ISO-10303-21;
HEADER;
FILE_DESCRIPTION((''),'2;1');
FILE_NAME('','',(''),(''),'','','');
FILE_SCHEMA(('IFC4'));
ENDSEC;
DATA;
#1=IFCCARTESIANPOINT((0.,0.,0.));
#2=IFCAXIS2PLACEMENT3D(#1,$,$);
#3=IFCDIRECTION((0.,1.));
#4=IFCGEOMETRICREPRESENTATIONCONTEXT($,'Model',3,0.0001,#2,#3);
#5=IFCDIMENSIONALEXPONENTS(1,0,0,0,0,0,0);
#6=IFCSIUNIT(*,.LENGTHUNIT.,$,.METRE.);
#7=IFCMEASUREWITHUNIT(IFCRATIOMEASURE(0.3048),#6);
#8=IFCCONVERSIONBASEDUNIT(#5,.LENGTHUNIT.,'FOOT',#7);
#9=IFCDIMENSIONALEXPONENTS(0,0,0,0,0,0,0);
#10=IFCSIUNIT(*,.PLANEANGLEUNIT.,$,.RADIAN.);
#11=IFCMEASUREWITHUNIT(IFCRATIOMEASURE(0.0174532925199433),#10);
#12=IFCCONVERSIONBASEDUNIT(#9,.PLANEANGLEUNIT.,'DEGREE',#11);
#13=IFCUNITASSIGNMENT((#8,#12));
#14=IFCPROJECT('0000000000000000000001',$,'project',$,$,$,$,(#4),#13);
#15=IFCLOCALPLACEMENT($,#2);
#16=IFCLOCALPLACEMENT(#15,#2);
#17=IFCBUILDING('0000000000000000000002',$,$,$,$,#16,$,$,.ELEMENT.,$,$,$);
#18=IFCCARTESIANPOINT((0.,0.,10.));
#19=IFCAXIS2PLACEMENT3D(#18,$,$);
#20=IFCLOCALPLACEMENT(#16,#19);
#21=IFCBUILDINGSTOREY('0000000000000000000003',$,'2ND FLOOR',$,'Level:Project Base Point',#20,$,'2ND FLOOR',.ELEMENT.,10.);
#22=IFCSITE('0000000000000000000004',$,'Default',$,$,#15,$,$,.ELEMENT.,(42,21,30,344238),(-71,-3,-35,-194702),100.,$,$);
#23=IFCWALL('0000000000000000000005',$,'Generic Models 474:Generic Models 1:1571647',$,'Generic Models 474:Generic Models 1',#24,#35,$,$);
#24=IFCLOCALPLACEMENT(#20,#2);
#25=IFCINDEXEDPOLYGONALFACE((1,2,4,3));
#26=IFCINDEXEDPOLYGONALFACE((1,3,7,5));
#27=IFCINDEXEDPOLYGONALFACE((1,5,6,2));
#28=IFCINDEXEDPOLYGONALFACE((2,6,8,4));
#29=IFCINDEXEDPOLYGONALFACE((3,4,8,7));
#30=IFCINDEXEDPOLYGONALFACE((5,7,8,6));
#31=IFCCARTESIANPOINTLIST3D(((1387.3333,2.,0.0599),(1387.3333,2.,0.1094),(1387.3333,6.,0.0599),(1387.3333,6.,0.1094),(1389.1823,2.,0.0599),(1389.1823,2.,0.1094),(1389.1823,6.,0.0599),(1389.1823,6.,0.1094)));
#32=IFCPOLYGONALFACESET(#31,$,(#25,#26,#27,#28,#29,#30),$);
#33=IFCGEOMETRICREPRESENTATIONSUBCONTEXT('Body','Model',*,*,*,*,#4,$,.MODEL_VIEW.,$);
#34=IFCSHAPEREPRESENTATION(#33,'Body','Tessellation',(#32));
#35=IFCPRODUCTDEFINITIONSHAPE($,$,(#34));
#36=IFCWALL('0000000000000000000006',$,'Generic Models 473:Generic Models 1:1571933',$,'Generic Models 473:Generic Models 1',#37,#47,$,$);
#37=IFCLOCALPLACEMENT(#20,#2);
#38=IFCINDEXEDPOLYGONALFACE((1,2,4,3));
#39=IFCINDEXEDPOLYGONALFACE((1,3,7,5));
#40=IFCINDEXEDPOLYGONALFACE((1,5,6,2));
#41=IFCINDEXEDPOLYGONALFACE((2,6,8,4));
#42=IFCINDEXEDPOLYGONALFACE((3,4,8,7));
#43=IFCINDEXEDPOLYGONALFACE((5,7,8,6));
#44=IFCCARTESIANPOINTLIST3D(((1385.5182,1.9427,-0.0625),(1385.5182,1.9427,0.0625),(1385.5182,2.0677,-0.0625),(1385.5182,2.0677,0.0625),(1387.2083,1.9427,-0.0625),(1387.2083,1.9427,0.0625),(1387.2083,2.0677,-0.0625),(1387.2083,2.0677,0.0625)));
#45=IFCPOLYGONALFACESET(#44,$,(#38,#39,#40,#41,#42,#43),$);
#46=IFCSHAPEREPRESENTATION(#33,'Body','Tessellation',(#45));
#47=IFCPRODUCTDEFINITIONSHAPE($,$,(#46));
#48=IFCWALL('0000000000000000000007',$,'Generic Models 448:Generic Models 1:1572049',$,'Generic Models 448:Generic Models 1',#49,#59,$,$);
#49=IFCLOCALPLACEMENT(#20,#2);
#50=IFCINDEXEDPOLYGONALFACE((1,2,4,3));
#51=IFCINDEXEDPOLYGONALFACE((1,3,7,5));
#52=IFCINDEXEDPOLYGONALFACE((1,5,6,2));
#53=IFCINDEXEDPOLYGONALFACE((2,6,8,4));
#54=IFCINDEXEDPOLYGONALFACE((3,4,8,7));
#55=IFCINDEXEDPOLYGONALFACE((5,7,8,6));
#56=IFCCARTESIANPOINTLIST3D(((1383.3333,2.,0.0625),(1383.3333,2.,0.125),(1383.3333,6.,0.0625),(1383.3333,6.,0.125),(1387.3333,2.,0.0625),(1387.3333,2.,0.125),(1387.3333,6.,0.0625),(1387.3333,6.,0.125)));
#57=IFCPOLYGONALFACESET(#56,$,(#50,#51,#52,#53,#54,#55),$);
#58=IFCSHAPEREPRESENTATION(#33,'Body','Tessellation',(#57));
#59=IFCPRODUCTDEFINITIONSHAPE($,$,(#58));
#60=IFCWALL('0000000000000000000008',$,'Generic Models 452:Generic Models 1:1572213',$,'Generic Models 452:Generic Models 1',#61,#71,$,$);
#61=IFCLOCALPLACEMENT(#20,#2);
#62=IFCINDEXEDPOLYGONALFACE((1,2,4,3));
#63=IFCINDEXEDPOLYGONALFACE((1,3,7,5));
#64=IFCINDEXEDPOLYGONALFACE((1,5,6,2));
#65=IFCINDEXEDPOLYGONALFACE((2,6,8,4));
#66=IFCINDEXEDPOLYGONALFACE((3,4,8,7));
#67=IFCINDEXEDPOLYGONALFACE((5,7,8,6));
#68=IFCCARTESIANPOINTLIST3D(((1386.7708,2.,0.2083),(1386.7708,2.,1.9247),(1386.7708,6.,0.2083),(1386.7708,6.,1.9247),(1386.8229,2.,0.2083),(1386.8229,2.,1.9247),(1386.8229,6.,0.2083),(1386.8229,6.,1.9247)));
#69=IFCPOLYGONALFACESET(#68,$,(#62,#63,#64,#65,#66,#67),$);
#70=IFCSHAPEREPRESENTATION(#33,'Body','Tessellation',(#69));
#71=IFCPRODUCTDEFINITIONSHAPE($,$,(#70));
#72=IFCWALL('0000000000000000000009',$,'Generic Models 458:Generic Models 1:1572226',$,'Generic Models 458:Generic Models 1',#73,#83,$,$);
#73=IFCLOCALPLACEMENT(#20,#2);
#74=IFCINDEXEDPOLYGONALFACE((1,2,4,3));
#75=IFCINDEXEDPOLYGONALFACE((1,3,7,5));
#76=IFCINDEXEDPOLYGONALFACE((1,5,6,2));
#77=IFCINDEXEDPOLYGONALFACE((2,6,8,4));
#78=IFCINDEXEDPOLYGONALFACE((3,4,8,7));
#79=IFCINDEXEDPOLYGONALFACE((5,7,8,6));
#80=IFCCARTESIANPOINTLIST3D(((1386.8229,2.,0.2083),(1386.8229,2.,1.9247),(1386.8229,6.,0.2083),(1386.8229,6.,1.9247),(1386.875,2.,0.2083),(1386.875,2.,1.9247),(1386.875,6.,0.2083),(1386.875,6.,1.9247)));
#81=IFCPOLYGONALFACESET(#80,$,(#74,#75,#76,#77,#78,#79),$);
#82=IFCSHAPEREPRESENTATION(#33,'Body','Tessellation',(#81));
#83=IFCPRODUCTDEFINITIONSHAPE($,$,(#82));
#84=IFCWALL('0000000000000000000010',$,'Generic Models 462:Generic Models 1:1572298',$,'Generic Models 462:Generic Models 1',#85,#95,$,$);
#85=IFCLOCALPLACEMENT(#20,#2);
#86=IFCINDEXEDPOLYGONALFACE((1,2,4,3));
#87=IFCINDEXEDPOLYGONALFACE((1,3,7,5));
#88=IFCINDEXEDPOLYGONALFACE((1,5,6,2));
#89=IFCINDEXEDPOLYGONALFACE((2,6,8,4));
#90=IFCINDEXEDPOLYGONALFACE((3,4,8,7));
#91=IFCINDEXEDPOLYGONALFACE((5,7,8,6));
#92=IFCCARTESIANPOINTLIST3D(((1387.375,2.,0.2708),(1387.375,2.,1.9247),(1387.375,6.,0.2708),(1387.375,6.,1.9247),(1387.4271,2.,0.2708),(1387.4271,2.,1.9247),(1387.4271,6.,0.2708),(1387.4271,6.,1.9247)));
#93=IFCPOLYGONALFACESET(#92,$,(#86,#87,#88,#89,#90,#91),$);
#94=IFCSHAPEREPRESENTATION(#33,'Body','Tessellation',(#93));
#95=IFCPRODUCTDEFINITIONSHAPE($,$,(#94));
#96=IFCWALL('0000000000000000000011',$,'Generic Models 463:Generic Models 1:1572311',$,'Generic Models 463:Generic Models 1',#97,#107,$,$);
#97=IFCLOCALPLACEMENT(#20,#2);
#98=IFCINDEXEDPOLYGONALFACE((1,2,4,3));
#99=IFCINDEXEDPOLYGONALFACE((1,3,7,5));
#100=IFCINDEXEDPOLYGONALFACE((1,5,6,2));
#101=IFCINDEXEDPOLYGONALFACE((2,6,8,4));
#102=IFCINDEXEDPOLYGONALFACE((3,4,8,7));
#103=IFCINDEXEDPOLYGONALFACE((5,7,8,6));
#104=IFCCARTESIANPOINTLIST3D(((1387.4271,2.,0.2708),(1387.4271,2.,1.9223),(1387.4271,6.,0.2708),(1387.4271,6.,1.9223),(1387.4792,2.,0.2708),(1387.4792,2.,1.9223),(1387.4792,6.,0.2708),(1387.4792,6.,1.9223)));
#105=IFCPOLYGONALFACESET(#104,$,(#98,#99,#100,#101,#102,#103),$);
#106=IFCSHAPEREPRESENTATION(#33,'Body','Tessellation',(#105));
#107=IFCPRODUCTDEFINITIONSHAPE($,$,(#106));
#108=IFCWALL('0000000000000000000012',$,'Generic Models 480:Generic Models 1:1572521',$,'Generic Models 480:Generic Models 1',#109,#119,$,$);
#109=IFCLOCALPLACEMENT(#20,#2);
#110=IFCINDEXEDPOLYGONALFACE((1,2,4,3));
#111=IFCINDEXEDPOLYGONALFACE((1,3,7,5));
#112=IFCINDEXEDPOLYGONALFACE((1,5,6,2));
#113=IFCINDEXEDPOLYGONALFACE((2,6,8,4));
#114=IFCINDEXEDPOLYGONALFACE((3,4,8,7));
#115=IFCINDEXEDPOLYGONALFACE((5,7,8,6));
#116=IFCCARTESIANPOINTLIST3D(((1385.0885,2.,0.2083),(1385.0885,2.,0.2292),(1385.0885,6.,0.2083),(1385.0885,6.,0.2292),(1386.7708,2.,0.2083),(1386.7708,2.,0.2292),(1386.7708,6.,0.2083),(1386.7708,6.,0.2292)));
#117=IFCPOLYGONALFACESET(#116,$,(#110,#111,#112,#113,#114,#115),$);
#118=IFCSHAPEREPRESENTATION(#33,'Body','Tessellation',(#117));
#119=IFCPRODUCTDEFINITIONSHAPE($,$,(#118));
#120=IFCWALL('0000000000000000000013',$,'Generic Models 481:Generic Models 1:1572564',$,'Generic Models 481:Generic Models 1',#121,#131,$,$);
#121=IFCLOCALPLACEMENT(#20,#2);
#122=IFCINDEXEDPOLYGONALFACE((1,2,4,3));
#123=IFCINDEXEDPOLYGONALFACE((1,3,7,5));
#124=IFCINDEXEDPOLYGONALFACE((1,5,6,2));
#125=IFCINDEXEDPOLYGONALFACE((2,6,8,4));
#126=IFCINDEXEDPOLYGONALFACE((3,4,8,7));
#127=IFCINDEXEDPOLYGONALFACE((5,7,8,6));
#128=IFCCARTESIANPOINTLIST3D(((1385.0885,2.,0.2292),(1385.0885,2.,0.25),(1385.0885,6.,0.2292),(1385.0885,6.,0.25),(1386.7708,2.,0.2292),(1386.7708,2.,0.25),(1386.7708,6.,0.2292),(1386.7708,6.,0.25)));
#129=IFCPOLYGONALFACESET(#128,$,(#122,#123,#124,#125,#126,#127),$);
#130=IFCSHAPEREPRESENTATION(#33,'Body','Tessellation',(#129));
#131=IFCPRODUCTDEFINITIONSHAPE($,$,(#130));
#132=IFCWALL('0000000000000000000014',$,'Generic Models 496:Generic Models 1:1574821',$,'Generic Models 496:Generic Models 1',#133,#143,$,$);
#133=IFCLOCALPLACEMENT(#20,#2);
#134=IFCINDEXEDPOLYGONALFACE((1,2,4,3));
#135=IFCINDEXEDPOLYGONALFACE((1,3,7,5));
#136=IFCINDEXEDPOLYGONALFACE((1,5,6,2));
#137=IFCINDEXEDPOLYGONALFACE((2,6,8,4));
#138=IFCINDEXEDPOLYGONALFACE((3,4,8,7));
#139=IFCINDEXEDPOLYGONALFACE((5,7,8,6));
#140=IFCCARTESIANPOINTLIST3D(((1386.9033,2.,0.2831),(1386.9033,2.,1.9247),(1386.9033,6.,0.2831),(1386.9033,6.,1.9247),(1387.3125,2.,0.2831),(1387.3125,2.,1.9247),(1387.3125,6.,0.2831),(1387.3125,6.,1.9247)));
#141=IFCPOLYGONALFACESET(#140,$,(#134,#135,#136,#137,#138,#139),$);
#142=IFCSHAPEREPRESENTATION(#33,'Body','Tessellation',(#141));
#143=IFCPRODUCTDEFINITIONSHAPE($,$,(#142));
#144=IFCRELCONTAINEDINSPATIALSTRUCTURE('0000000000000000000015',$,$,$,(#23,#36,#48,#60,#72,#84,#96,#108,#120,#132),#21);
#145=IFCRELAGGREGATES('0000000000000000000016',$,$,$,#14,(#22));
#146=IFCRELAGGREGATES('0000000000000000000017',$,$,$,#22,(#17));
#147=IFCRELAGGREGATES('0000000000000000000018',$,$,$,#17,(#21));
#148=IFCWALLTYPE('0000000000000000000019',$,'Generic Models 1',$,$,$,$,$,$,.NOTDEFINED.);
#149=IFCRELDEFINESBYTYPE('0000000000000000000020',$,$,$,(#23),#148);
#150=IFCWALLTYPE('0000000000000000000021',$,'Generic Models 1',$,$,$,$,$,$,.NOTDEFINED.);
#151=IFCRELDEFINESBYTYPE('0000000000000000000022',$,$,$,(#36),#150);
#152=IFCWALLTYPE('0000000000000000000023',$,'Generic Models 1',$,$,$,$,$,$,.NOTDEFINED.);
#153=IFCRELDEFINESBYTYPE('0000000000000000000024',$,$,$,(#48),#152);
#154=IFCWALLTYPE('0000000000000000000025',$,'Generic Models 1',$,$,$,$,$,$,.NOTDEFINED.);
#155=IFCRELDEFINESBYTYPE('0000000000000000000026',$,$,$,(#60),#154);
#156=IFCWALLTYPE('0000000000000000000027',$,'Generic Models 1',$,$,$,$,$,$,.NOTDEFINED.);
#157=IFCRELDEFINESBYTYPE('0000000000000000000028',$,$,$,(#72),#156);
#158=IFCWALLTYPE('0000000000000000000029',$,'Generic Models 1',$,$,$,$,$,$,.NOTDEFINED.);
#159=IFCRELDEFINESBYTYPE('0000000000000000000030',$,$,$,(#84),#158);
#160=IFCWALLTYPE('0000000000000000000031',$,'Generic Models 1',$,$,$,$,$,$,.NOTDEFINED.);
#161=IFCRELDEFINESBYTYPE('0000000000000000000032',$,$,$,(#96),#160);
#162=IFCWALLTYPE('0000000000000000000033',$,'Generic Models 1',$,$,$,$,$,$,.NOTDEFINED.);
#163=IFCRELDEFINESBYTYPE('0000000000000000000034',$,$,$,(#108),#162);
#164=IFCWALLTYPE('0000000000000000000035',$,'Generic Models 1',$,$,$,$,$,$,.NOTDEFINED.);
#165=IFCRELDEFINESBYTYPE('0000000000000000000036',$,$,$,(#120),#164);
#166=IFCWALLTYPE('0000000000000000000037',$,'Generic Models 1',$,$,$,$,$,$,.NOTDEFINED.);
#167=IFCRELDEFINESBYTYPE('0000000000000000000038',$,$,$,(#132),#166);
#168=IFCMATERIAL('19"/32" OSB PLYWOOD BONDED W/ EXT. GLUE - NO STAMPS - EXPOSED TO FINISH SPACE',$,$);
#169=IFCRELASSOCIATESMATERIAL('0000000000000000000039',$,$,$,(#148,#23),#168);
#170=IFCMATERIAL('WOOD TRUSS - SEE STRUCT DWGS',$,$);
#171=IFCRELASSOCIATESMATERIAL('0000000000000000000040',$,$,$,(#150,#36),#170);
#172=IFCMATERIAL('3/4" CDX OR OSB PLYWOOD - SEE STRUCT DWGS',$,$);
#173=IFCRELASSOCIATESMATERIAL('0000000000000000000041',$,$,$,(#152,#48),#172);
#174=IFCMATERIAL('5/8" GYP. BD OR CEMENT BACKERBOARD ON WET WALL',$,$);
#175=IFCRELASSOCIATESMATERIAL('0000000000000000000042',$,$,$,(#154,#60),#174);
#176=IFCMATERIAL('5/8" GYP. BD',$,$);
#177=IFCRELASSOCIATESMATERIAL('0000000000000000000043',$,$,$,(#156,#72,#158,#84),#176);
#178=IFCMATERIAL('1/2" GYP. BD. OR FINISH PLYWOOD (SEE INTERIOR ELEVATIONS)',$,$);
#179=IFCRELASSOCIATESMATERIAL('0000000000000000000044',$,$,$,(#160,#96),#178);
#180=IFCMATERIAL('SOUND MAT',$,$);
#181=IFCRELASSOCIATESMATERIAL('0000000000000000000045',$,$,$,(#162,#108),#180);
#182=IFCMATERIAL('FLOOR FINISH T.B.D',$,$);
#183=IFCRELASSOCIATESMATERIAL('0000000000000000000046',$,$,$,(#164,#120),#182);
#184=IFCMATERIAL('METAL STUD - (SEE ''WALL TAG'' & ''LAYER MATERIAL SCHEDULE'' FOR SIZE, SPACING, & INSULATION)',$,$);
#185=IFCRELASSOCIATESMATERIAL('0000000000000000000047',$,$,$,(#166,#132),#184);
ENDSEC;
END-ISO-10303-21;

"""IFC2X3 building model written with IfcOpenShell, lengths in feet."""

from ifc_helpers import new_model, entity, si_unit, converted_unit, direction, frame, frame_2d, origin, origin_2d_with_axis, place, context, subcontext, project, spatial, rectangle, extrude, material, type_object, element, save


model = new_model("IFC2X3")

# Units and contexts
model_context = context("Model", 3, precision=0.0001, world=origin(), true_north=direction((0.0, 1.0)))
body_context = subcontext(model_context, "Body", "Model", "MODEL_VIEW")
ifc_project = project(units=[converted_unit("LENGTHUNIT", "FOOT", entity("IfcRatioMeasure", 0.3048), si_unit("LENGTHUNIT", "METRE"), dimensions=[1, 0, 0, 0, 0, 0, 0]), converted_unit("PLANEANGLEUNIT", "DEGREE", entity("IfcRatioMeasure", 0.0174532925199433), si_unit("PLANEANGLEUNIT", "RADIAN"), dimensions=[0, 0, 0, 0, 0, 0, 0])], contexts=[model_context])

# Site, building, storey
site_placement = place(None, origin())
site = spatial("IfcSite", under=ifc_project, at=site_placement, Name="Default", CompositionType="ELEMENT", RefLatitude=(42, 21, 30, 344238), RefLongitude=(-71, -3, -35, -194702), RefElevation=100.0)
building_placement = place(site_placement, origin())
building = spatial("IfcBuilding", under=site, at=building_placement, CompositionType="ELEMENT")
storey_placement = place(building_placement, frame((0.0, 0.0, 10.0)))
storey = spatial("IfcBuildingStorey", under=building, at=storey_placement, Name="2ND FLOOR", ObjectType="Level:Project Base Point", LongName="2ND FLOOR", CompositionType="ELEMENT", Elevation=10.0)

# Walls
ifc_material_1 = material(Name="3/4\" CDX OR OSB PLYWOOD - SEE STRUCT DWGS")
ifc_material_2 = material(Name="WOOD TRUSS - SEE STRUCT DWGS")
ifc_material_3 = material(Name="SOUND MAT")
ifc_material_4 = material(Name="19\"/32\" OSB PLYWOOD BONDED W/ EXT. GLUE - NO STAMPS - EXPOSED TO FINISH SPACE")
wall_type_1 = type_object("IfcWallType", Name="Generic Models 1", PredefinedType="NOTDEFINED", material=ifc_material_4)
wall_1_placement = place(storey_placement, frame((1387.3333, 2.0, 0.0599), z_axis=(0.0, 0.0, 1.0), x_axis=(0.0, 1.0, 0.0)))
element("IfcWall", 1, at=wall_1_placement, inside=storey, type_object=wall_type_1, material=ifc_material_4, Name="Generic Models 474:Generic Models 1:1571647", ObjectType="Generic Models 474:Generic Models 1", context=body_context, shape_type="SweptSolid", body=[
    extrude(rectangle(XDim=4.0, YDim=1.849, at=frame_2d((0.0, 0.0), x_axis=(1.0, 0.0))), frame((2.0, -0.9245, 0.0)), (0.0, 0.0, 1.0), 0.0495),
])
wall_type_2 = type_object("IfcWallType", Name="Generic Models 1", PredefinedType="NOTDEFINED", material=ifc_material_2)
wall_2_placement = place(storey_placement, frame((1385.5182, 1.9427, -0.0625)))
element("IfcWall", 2, at=wall_2_placement, inside=storey, type_object=wall_type_2, material=ifc_material_2, Name="Generic Models 473:Generic Models 1:1571933", ObjectType="Generic Models 473:Generic Models 1", context=body_context, shape_type="SweptSolid", body=[
    extrude(rectangle(XDim=0.125, YDim=1.6902, at=frame_2d((0.0, 0.0), x_axis=(1.0, 0.0))), frame((0.8451, 0.0625, 0.0), z_axis=(0.0, 0.0, 1.0), x_axis=(0.0, 1.0, 0.0)), (0.0, 0.0, 1.0), 0.125),
])
wall_type_3 = type_object("IfcWallType", Name="Generic Models 1", PredefinedType="NOTDEFINED", material=ifc_material_1)
wall_3_placement = place(storey_placement, frame((1383.3333, 2.0, 0.0625), z_axis=(0.0, 0.0, 1.0), x_axis=(0.0, 1.0, 0.0)))
element("IfcWall", 3, at=wall_3_placement, inside=storey, type_object=wall_type_3, material=ifc_material_1, Name="Generic Models 448:Generic Models 1:1572049", ObjectType="Generic Models 448:Generic Models 1", context=body_context, shape_type="SweptSolid", body=[
    extrude(rectangle(XDim=4.0, YDim=4.0, at=frame_2d((0.0, 0.0), x_axis=(1.0, 0.0))), frame((2.0, -2.0, 0.0)), (0.0, 0.0, 1.0), 0.0625),
])
ifc_material_5 = material(Name="5/8\" GYP. BD OR CEMENT BACKERBOARD ON WET WALL")
wall_type_4 = type_object("IfcWallType", Name="Generic Models 1", PredefinedType="NOTDEFINED", material=ifc_material_5)
wall_4_placement = place(storey_placement, frame((1386.7708, 2.0, 0.2083), z_axis=(0.0, 0.0, 1.0), x_axis=(0.0, 1.0, 0.0)))
element("IfcWall", 4, at=wall_4_placement, inside=storey, type_object=wall_type_4, material=ifc_material_5, Name="Generic Models 452:Generic Models 1:1572213", ObjectType="Generic Models 452:Generic Models 1", context=body_context, shape_type="SweptSolid", body=[
    extrude(rectangle(XDim=4.0, YDim=0.0521, at=frame_2d((0.0, 0.0), x_axis=(1.0, 0.0))), frame((2.0, -0.026, 0.0)), (0.0, 0.0, 1.0), 1.7163),
])
ifc_material_6 = material(Name="5/8\" GYP. BD")
wall_type_5 = type_object("IfcWallType", Name="Generic Models 1", PredefinedType="NOTDEFINED", material=ifc_material_6)
wall_5_placement = place(storey_placement, frame((1386.8229, 2.0, 0.2083), z_axis=(0.0, 0.0, 1.0), x_axis=(0.0, 1.0, 0.0)))
element("IfcWall", 5, at=wall_5_placement, inside=storey, type_object=wall_type_5, material=ifc_material_6, Name="Generic Models 458:Generic Models 1:1572226", ObjectType="Generic Models 458:Generic Models 1", context=body_context, shape_type="SweptSolid", body=[
    extrude(rectangle(XDim=4.0, YDim=0.0521, at=frame_2d((0.0, 0.0), x_axis=(1.0, 0.0))), frame((2.0, -0.026, 0.0)), (0.0, 0.0, 1.0), 1.7163),
])
wall_type_6 = type_object("IfcWallType", Name="Generic Models 1", PredefinedType="NOTDEFINED", material=ifc_material_6)
wall_6_placement = place(storey_placement, frame((1387.375, 2.0, 0.2708), z_axis=(0.0, 0.0, 1.0), x_axis=(0.0, 1.0, 0.0)))
element("IfcWall", 6, at=wall_6_placement, inside=storey, type_object=wall_type_6, material=ifc_material_6, Name="Generic Models 462:Generic Models 1:1572298", ObjectType="Generic Models 462:Generic Models 1", context=body_context, shape_type="SweptSolid", body=[
    extrude(rectangle(XDim=4.0, YDim=0.0521, at=origin_2d_with_axis()), frame((2.0, -0.026, 0.0)), (0.0, 0.0, 1.0), 1.6538),
])
ifc_material_7 = material(Name="1/2\" GYP. BD. OR FINISH PLYWOOD (SEE INTERIOR ELEVATIONS)")
wall_type_7 = type_object("IfcWallType", Name="Generic Models 1", PredefinedType="NOTDEFINED", material=ifc_material_7)
wall_7_placement = place(storey_placement, frame((1387.4271, 2.0, 0.2708), z_axis=(0.0, 0.0, 1.0), x_axis=(0.0, 1.0, 0.0)))
element("IfcWall", 7, at=wall_7_placement, inside=storey, type_object=wall_type_7, material=ifc_material_7, Name="Generic Models 463:Generic Models 1:1572311", ObjectType="Generic Models 463:Generic Models 1", context=body_context, shape_type="SweptSolid", body=[
    extrude(rectangle(XDim=4.0, YDim=0.0521, at=frame_2d((0.0, 0.0), x_axis=(1.0, 0.0))), frame((2.0, -0.026, 0.0)), (0.0, 0.0, 1.0), 1.6515),
])
wall_type_8 = type_object("IfcWallType", Name="Generic Models 1", PredefinedType="NOTDEFINED", material=ifc_material_3)
wall_8_placement = place(storey_placement, frame((1385.0885, 2.0, 0.2083), z_axis=(0.0, 0.0, 1.0), x_axis=(0.0, 1.0, 0.0)))
element("IfcWall", 8, at=wall_8_placement, inside=storey, type_object=wall_type_8, material=ifc_material_3, Name="Generic Models 480:Generic Models 1:1572521", ObjectType="Generic Models 480:Generic Models 1", context=body_context, shape_type="SweptSolid", body=[
    extrude(rectangle(XDim=4.0, YDim=1.6823, at=origin_2d_with_axis()), frame((2.0, -0.8411, 0.0)), (0.0, 0.0, 1.0), 0.0208),
])
ifc_material_8 = material(Name="FLOOR FINISH T.B.D")
wall_type_9 = type_object("IfcWallType", Name="Generic Models 1", PredefinedType="NOTDEFINED", material=ifc_material_8)
wall_9_placement = place(storey_placement, frame((1385.0885, 2.0, 0.2292), z_axis=(0.0, 0.0, 1.0), x_axis=(0.0, 1.0, 0.0)))
element("IfcWall", 9, at=wall_9_placement, inside=storey, type_object=wall_type_9, material=ifc_material_8, Name="Generic Models 481:Generic Models 1:1572564", ObjectType="Generic Models 481:Generic Models 1", context=body_context, shape_type="SweptSolid", body=[
    extrude(rectangle(XDim=4.0, YDim=1.6823, at=origin_2d_with_axis()), frame((2.0, -0.8411, 0.0)), (0.0, 0.0, 1.0), 0.0208),
])
ifc_material_9 = material(Name="METAL STUD - (SEE 'WALL TAG' & 'LAYER MATERIAL SCHEDULE' FOR SIZE, SPACING, & INSULATION)")
wall_type_10 = type_object("IfcWallType", Name="Generic Models 1", PredefinedType="NOTDEFINED", material=ifc_material_9)
wall_10_placement = place(storey_placement, frame((1386.9033, 2.0, 0.2831), z_axis=(0.0, 0.0, 1.0), x_axis=(0.0, 1.0, 0.0)))
element("IfcWall", 10, at=wall_10_placement, inside=storey, type_object=wall_type_10, material=ifc_material_9, Name="Generic Models 496:Generic Models 1:1574821", ObjectType="Generic Models 496:Generic Models 1", context=body_context, shape_type="SweptSolid", body=[
    extrude(rectangle(XDim=4.0, YDim=0.4092, at=frame_2d((0.0, 0.0), x_axis=(1.0, 0.0))), frame((2.0, -0.2046, 0.0)), (0.0, 0.0, 1.0), 1.6416),
])

save(model, "model.ifc")
